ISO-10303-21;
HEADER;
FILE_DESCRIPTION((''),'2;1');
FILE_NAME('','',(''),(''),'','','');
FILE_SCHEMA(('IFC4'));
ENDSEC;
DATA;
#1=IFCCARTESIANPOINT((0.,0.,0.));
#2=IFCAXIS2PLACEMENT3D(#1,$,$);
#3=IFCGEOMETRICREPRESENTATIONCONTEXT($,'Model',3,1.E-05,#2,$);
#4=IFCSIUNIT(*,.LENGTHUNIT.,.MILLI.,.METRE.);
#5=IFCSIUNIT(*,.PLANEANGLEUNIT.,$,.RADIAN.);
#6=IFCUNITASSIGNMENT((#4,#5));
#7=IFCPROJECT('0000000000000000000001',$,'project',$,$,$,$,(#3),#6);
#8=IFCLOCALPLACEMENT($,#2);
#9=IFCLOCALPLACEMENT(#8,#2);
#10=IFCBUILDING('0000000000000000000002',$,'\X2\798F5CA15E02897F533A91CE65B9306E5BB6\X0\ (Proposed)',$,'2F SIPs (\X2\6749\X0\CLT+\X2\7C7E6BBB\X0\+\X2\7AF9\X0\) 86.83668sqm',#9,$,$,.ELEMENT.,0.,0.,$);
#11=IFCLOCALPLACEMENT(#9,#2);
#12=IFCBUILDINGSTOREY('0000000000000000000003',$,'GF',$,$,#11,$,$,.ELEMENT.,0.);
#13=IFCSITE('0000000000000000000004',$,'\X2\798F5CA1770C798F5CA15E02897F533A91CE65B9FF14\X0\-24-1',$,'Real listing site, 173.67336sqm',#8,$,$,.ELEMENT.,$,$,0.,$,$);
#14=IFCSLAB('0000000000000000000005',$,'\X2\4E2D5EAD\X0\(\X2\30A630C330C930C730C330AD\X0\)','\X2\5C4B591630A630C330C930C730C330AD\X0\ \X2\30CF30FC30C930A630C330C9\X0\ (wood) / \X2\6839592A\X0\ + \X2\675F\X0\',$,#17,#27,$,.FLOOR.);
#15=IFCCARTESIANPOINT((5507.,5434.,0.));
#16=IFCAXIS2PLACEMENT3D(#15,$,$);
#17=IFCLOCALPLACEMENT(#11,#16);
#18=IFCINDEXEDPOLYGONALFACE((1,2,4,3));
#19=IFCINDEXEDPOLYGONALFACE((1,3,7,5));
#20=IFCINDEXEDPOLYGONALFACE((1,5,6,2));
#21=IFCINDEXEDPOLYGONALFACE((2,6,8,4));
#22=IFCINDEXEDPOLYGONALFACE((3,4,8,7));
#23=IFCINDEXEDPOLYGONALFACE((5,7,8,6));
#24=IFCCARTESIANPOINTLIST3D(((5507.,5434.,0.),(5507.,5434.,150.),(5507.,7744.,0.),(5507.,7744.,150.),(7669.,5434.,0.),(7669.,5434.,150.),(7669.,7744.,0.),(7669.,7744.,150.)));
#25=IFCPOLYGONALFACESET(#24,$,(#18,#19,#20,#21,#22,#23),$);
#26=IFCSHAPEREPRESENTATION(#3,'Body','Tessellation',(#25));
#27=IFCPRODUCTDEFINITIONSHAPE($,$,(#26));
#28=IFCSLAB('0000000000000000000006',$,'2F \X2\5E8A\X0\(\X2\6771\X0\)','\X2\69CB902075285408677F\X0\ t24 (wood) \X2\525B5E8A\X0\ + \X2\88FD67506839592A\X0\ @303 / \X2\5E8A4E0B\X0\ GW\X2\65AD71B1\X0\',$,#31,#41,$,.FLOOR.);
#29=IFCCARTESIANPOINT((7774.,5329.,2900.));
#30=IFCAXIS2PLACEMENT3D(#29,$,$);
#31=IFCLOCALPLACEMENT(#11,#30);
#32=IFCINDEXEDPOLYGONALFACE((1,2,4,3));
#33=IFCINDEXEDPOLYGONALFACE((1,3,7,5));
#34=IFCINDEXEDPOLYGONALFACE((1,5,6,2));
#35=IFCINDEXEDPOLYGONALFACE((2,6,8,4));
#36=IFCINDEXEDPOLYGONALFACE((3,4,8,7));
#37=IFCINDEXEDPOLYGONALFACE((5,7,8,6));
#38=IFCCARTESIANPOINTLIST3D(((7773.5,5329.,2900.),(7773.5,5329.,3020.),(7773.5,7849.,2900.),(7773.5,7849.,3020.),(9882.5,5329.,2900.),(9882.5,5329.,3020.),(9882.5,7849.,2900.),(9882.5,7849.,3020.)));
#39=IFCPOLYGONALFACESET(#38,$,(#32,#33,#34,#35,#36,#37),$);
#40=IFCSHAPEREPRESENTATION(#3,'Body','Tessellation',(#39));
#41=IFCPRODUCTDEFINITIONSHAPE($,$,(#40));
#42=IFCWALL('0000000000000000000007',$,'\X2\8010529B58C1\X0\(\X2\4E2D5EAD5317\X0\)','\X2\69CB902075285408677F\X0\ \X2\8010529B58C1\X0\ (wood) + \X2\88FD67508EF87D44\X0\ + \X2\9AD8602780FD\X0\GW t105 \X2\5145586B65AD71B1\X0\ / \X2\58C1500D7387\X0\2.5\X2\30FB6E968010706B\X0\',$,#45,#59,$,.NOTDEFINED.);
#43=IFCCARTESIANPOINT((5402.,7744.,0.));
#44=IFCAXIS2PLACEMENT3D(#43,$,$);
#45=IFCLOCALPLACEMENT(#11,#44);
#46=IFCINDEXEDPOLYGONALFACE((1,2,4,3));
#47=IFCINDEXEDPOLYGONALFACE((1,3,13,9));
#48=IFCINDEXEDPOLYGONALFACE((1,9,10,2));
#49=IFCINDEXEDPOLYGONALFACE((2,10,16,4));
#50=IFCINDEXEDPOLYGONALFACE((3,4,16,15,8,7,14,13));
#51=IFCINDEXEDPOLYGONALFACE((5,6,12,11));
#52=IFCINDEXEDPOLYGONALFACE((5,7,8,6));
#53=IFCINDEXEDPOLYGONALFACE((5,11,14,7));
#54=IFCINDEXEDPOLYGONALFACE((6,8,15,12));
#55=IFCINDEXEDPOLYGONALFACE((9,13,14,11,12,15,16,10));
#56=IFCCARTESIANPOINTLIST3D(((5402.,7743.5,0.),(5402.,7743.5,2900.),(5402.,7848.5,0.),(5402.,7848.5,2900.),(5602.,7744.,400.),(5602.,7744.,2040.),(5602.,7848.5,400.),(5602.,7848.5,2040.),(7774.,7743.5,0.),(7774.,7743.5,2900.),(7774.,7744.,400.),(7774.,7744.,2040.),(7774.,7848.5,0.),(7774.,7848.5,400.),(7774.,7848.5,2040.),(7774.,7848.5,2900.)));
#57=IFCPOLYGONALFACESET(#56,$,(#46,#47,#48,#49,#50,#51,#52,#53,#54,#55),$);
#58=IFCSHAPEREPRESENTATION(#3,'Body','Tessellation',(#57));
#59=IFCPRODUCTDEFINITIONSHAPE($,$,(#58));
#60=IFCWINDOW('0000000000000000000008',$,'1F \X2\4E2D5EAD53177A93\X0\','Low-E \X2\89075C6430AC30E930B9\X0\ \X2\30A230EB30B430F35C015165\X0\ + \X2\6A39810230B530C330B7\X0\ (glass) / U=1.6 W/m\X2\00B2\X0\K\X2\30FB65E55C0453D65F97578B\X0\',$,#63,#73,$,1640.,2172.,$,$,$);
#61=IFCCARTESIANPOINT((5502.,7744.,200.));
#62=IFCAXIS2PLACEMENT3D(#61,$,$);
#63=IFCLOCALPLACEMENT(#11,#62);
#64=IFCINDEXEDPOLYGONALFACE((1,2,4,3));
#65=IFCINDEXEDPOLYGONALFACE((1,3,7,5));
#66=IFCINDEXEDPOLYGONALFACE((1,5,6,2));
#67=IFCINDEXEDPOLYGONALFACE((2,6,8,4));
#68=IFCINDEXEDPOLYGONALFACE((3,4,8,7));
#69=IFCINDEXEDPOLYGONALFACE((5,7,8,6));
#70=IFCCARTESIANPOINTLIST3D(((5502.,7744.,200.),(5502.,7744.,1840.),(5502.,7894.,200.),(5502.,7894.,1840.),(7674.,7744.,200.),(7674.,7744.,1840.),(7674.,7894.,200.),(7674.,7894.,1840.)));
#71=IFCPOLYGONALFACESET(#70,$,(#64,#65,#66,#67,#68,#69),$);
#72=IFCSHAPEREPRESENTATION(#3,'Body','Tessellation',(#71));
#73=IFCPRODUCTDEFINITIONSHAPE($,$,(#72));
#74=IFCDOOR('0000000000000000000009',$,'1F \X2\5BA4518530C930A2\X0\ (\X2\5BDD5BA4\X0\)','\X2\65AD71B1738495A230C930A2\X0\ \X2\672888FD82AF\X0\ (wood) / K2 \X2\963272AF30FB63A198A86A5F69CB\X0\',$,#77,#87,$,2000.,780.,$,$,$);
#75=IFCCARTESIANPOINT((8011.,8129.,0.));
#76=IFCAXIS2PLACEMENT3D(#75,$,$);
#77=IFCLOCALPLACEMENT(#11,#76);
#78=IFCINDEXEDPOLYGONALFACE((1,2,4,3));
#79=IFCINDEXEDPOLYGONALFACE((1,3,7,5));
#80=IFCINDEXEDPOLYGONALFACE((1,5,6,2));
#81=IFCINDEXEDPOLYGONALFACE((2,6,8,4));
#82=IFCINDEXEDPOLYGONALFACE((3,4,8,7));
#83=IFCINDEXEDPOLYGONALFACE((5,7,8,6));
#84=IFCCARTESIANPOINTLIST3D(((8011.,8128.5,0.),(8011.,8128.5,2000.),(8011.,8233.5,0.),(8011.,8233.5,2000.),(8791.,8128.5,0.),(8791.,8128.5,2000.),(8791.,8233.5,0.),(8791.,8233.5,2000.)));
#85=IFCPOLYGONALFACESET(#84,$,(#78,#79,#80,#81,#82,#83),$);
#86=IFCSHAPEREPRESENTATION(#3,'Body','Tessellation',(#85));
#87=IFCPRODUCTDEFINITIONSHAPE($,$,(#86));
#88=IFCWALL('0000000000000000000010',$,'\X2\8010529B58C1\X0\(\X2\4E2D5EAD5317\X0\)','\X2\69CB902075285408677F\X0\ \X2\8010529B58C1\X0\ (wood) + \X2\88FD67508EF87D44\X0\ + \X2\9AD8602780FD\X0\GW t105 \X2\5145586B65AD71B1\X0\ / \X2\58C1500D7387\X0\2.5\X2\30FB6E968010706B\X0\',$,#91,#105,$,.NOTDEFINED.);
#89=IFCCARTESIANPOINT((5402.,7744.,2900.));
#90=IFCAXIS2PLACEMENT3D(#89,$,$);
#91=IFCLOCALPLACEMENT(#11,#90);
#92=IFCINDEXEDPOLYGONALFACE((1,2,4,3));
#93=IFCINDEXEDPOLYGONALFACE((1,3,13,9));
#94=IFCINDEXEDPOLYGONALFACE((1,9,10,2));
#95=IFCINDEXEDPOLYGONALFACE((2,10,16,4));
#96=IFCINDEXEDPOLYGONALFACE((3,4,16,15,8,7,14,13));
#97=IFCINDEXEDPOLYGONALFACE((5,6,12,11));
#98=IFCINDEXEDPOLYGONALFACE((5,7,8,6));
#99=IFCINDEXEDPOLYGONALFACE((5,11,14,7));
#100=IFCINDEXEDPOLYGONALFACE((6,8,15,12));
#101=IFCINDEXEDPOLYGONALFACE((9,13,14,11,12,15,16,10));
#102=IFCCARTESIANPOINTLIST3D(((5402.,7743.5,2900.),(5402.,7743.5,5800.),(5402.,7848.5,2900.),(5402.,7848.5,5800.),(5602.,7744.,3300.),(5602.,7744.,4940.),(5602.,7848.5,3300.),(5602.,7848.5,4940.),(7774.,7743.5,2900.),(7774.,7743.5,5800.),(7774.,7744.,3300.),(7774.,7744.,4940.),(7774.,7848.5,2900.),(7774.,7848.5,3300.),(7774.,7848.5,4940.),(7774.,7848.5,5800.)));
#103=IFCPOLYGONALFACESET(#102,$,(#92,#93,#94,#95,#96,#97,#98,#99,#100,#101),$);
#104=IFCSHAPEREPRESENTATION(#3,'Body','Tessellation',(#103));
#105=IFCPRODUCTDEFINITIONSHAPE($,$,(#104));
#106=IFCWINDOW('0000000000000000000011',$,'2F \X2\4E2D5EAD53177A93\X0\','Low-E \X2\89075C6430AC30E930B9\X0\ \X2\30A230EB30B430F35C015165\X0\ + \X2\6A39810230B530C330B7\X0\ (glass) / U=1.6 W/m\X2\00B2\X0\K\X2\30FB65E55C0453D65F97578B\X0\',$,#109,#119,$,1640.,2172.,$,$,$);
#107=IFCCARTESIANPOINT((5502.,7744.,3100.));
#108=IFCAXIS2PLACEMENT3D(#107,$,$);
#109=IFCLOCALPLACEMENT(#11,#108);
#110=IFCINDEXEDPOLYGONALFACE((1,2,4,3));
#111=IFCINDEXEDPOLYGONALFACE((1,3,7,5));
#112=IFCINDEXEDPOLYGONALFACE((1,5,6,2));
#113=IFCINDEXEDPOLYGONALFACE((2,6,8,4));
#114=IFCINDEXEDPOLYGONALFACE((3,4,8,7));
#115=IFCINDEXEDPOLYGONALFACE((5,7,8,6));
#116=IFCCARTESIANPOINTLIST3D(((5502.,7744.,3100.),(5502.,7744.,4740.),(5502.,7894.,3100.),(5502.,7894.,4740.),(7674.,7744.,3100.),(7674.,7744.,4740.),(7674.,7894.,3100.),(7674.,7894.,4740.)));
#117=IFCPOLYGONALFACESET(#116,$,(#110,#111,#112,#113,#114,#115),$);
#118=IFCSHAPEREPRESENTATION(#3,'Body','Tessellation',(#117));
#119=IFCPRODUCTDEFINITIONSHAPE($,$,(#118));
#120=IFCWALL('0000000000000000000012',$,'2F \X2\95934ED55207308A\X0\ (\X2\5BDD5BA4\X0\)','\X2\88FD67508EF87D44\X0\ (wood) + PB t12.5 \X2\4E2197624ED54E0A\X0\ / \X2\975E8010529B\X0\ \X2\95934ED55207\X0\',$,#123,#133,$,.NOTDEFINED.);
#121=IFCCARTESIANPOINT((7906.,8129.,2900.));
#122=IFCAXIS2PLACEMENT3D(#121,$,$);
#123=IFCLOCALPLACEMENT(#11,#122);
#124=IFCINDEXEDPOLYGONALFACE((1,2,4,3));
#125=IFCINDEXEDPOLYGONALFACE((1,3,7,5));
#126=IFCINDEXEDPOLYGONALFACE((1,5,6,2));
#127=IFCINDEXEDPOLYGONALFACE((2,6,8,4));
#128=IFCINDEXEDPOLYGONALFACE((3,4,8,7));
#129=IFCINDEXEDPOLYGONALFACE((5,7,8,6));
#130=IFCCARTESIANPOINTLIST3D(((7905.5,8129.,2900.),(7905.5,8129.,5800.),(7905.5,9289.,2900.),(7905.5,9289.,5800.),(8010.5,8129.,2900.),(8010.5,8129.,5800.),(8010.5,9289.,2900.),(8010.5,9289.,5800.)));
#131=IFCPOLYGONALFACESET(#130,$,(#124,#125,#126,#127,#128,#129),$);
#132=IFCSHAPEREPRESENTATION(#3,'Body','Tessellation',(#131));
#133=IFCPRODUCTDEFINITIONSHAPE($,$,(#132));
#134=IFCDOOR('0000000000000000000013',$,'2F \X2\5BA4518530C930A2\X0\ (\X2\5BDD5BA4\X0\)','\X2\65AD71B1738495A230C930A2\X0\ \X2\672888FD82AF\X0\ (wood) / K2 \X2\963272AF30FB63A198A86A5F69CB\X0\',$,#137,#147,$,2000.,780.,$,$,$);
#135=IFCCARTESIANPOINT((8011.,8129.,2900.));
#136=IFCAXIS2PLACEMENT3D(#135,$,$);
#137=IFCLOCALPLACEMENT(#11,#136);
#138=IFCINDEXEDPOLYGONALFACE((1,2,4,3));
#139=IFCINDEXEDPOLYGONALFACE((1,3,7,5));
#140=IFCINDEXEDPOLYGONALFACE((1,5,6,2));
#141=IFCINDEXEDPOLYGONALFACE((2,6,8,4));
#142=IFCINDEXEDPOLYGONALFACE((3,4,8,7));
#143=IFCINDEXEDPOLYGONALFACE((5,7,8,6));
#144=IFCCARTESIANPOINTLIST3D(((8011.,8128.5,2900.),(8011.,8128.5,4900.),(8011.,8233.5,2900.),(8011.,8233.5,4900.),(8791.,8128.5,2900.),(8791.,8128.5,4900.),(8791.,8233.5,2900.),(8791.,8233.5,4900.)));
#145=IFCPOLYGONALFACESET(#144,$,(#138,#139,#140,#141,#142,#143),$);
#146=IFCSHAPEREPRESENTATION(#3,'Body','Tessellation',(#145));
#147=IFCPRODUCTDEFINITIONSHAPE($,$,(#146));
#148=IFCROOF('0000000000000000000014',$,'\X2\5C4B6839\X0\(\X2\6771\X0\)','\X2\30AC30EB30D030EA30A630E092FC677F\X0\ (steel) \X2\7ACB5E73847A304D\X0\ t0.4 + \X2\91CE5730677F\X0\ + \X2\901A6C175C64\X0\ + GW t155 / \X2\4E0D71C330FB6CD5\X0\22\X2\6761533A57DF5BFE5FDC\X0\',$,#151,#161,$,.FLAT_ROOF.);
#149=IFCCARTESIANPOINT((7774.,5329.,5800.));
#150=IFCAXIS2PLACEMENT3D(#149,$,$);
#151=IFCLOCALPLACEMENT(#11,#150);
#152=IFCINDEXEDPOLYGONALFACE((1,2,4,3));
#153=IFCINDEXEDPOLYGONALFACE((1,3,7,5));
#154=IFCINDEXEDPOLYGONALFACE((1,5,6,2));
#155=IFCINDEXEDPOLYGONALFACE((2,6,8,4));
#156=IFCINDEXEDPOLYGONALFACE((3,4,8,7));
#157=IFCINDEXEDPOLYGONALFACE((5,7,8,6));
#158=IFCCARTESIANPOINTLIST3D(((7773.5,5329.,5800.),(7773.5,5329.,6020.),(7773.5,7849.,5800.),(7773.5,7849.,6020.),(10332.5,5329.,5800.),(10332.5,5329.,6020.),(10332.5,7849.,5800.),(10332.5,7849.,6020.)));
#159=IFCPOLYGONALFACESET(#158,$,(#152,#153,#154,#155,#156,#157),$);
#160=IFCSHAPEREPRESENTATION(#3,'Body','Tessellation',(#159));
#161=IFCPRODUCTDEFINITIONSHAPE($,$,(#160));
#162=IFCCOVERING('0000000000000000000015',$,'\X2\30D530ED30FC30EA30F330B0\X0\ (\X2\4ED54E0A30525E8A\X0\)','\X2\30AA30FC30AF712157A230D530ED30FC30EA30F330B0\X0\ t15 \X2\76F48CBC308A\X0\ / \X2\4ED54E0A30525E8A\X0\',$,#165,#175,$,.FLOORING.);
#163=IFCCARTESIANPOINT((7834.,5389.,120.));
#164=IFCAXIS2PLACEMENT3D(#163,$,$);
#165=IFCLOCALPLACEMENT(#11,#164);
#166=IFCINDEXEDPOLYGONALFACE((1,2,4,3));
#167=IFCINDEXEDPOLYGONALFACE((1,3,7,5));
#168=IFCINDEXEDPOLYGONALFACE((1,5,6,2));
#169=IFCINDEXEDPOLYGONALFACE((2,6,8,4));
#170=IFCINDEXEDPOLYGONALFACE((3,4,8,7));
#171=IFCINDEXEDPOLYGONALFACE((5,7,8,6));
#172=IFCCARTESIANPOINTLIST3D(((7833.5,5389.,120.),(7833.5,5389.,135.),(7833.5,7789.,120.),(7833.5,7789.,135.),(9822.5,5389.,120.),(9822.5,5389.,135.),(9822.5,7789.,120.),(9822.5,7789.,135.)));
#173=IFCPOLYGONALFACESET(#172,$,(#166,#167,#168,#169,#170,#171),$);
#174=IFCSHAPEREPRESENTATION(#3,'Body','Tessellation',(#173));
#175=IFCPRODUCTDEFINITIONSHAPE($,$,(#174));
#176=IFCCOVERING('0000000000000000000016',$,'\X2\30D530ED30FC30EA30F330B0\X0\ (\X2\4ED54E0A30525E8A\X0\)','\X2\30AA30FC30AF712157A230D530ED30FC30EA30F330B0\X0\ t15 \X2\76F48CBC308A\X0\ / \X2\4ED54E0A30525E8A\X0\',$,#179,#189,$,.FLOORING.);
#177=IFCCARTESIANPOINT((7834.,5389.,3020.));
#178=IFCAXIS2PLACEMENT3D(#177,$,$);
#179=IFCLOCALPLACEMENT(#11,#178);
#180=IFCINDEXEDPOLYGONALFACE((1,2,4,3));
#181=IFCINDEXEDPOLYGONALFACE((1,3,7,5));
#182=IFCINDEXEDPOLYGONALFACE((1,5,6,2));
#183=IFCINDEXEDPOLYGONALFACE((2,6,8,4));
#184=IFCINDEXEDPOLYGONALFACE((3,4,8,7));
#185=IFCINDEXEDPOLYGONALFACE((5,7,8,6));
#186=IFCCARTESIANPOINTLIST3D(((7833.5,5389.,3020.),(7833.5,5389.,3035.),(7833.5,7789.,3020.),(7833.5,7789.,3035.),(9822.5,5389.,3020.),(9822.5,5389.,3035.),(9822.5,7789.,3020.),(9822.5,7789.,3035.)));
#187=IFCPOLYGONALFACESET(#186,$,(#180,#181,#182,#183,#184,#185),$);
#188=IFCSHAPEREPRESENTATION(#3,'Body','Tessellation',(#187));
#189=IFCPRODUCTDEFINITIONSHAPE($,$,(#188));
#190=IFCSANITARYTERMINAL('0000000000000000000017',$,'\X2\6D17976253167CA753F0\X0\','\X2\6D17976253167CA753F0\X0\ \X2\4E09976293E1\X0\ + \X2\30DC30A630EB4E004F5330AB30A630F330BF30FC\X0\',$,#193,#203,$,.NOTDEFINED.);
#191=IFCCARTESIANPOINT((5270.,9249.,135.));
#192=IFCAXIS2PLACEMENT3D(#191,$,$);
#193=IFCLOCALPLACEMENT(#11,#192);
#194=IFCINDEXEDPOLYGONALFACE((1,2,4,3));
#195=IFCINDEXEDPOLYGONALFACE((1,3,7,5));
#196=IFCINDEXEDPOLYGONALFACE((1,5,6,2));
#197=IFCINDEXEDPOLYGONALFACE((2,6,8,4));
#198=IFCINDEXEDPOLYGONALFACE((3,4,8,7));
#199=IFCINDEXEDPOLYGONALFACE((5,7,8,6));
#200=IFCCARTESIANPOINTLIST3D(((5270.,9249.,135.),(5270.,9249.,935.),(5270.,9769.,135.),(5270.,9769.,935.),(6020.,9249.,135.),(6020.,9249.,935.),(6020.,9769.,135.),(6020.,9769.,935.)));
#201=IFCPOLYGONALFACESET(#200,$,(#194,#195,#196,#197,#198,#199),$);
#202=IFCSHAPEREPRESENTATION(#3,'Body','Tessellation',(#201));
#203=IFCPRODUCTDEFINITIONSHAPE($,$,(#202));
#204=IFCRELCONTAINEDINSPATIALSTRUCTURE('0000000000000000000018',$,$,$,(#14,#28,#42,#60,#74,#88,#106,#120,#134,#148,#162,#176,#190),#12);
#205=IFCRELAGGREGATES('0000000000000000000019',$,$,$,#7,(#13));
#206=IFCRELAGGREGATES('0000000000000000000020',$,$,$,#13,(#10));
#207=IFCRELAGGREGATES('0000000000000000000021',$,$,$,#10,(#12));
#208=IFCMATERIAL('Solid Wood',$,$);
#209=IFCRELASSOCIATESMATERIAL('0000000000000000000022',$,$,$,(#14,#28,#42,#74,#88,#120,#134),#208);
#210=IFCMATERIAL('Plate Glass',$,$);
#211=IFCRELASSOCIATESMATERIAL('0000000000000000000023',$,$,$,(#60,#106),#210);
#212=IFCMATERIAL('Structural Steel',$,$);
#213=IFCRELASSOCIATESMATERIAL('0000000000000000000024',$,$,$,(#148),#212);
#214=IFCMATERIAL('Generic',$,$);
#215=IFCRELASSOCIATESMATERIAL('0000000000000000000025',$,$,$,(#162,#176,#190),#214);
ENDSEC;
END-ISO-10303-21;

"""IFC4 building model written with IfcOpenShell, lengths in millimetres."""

from ifc_helpers import new_model, si_unit, frame, frame_2d, origin, place, context, project, spatial, rectangle, extrude, material, element, fill, save


model = new_model("IFC4")

# Units and contexts
model_context = context("Model", 3, precision=1e-05, world=origin())
ifc_project = project(units=[si_unit("LENGTHUNIT", "METRE", prefix="MILLI"), si_unit("PLANEANGLEUNIT", "RADIAN")], contexts=[model_context])

# Site, building, storey
site_placement = place(None, origin())
site = spatial("IfcSite", under=ifc_project, at=site_placement, Name="福岡県福岡市西区野方４-24-1", ObjectType="Real listing site, 173.67336sqm", CompositionType="ELEMENT", RefElevation=0.0)
building_placement = place(site_placement, origin())
building = spatial("IfcBuilding", under=site, at=building_placement, Name="福岡市西区野方の家 (Proposed)", ObjectType="2F SIPs (杉CLT+籾殻+竹) 86.83668sqm", CompositionType="ELEMENT", ElevationOfRefHeight=0.0, ElevationOfTerrain=0.0)
storey_placement = place(building_placement, origin())
storey = spatial("IfcBuildingStorey", under=building, at=storey_placement, Name="GF", CompositionType="ELEMENT", Elevation=0.0)

# Slabs
ifc_material_1 = material(Name="Solid Wood")
slab_1_placement = place(storey_placement, frame((5507.0, 5434.0, 0.0)))
element("IfcSlab", 1, at=slab_1_placement, inside=storey, material=ifc_material_1, Name="中庭(ウッドデッキ)", Description="屋外ウッドデッキ ハードウッド (wood) / 根太 + 束", PredefinedType="FLOOR", context=model_context, shape_type="SweptSolid", body=[
    extrude(rectangle(XDim=2162.0, YDim=2310.0, at=frame_2d((1081.0, 1155.0))), frame((5507.0, 5434.0, 0.0)), (0.0, 0.0, 1.0), 150.0),
])
slab_2_placement = place(storey_placement, frame((7774.0, 5329.0, 2900.0)))
element("IfcSlab", 2, at=slab_2_placement, inside=storey, material=ifc_material_1, Name="2F 床(東)", Description="構造用合板 t24 (wood) 剛床 + 製材根太 @303 / 床下 GW断熱", PredefinedType="FLOOR", context=model_context, shape_type="SweptSolid", body=[
    extrude(rectangle(XDim=2109.0, YDim=2520.0, at=frame_2d((1054.0, 1260.0))), frame((7774.0, 5329.0, 2900.0)), (0.0, 0.0, 1.0), 120.0),
])

# Wall, opening, window
wall_1_placement = place(storey_placement, frame((5402.0, 7744.0, 0.0)))
wall_1 = element("IfcWall", 3, at=wall_1_placement, inside=storey, material=ifc_material_1, Name="耐力壁(中庭北)", Description="構造用合板 耐力壁 (wood) + 製材軸組 + 高性能GW t105 充填断熱 / 壁倍率2.5・準耐火", PredefinedType="NOTDEFINED", context=model_context, shape_type="SweptSolid", body=[
    extrude(rectangle(XDim=2372.0, YDim=105.0, at=frame_2d((1186.0, 52.0))), frame((5402.0, 7744.0, 0.0)), (0.0, 0.0, 1.0), 2900.0),
])
opening_1_placement = place(storey_placement, frame((5502.0, 7744.0, 200.0)))
opening_1 = element("IfcOpeningElement", 4, at=opening_1_placement, cuts=wall_1, PredefinedType="NOTDEFINED", context=model_context, shape_type="SweptSolid", body=[
    extrude(rectangle(XDim=2172.0, YDim=150.0, at=frame_2d((1086.0, 75.0))), frame((5502.0, 7744.0, 200.0)), (0.0, 0.0, 1.0), 1640.0),
])
ifc_material_2 = material(Name="Plate Glass")
window_1_placement = place(storey_placement, frame((5502.0, 7744.0, 200.0)))
window_1 = element("IfcWindow", 5, at=window_1_placement, inside=storey, material=ifc_material_2, Name="1F 中庭北窓", Description="Low-E 複層ガラス アルゴン封入 + 樹脂サッシ (glass) / U=1.6 W/m²K・日射取得型", OverallHeight=1640.0, OverallWidth=2172.0, context=model_context, shape_type="SweptSolid", body=[
    extrude(rectangle(XDim=2172.0, YDim=150.0, at=frame_2d((1086.0, 75.0))), frame((5502.0, 7744.0, 200.0)), (0.0, 0.0, 1.0), 1640.0),
])
fill(opening_1, window_1)

# Door
door_1_placement = place(storey_placement, frame((8011.0, 8129.0, 0.0)))
element("IfcDoor", 6, at=door_1_placement, inside=storey, material=ifc_material_1, Name="1F 室内ドア (寝室)", Description="断熱玄関ドア 木製芯 (wood) / K2 防犯・採風機構", OverallHeight=2000.0, OverallWidth=780.0, context=model_context, shape_type="SweptSolid", body=[
    extrude(rectangle(XDim=780.0, YDim=105.0, at=frame_2d((390.0, 52.0))), frame((8011.0, 8129.0, 0.0)), (0.0, 0.0, 1.0), 2000.0),
])

# Wall, opening, window
wall_2_placement = place(storey_placement, frame((5402.0, 7744.0, 2900.0)))
wall_2 = element("IfcWall", 7, at=wall_2_placement, inside=storey, material=ifc_material_1, Name="耐力壁(中庭北)", Description="構造用合板 耐力壁 (wood) + 製材軸組 + 高性能GW t105 充填断熱 / 壁倍率2.5・準耐火", PredefinedType="NOTDEFINED", context=model_context, shape_type="SweptSolid", body=[
    extrude(rectangle(XDim=2372.0, YDim=105.0, at=frame_2d((1186.0, 52.0))), frame((5402.0, 7744.0, 2900.0)), (0.0, 0.0, 1.0), 2900.0),
])
opening_2_placement = place(storey_placement, frame((5502.0, 7744.0, 3100.0)))
opening_2 = element("IfcOpeningElement", 8, at=opening_2_placement, cuts=wall_2, PredefinedType="NOTDEFINED", context=model_context, shape_type="SweptSolid", body=[
    extrude(rectangle(XDim=2172.0, YDim=150.0, at=frame_2d((1086.0, 75.0))), frame((5502.0, 7744.0, 3100.0)), (0.0, 0.0, 1.0), 1640.0),
])
window_2_placement = place(storey_placement, frame((5502.0, 7744.0, 3100.0)))
window_2 = element("IfcWindow", 9, at=window_2_placement, inside=storey, material=ifc_material_2, Name="2F 中庭北窓", Description="Low-E 複層ガラス アルゴン封入 + 樹脂サッシ (glass) / U=1.6 W/m²K・日射取得型", OverallHeight=1640.0, OverallWidth=2172.0, context=model_context, shape_type="SweptSolid", body=[
    extrude(rectangle(XDim=2172.0, YDim=150.0, at=frame_2d((1086.0, 75.0))), frame((5502.0, 7744.0, 3100.0)), (0.0, 0.0, 1.0), 1640.0),
])
fill(opening_2, window_2)

# Wall
wall_3_placement = place(storey_placement, frame((7906.0, 8129.0, 2900.0)))
element("IfcWall", 10, at=wall_3_placement, inside=storey, material=ifc_material_1, Name="2F 間仕切り (寝室)", Description="製材軸組 (wood) + PB t12.5 両面仕上 / 非耐力 間仕切", PredefinedType="NOTDEFINED", context=model_context, shape_type="SweptSolid", body=[
    extrude(rectangle(XDim=105.0, YDim=1160.0, at=frame_2d((52.0, 580.0))), frame((7906.0, 8129.0, 2900.0)), (0.0, 0.0, 1.0), 2900.0),
])

# Door
door_2_placement = place(storey_placement, frame((8011.0, 8129.0, 2900.0)))
element("IfcDoor", 11, at=door_2_placement, inside=storey, material=ifc_material_1, Name="2F 室内ドア (寝室)", Description="断熱玄関ドア 木製芯 (wood) / K2 防犯・採風機構", OverallHeight=2000.0, OverallWidth=780.0, context=model_context, shape_type="SweptSolid", body=[
    extrude(rectangle(XDim=780.0, YDim=105.0, at=frame_2d((390.0, 52.0))), frame((8011.0, 8129.0, 2900.0)), (0.0, 0.0, 1.0), 2000.0),
])

# Roof
ifc_material_3 = material(Name="Structural Steel")
for number, where, name in (
    (12, (7774.0, 5329.0, 5800.0), "屋根(東)"),
):
    element("IfcRoof", number, at=place(storey_placement, frame(where)), inside=storey, material=ifc_material_3, Name=name, Description="ガルバリウム鋼板 (steel) 立平葺き t0.4 + 野地板 + 通気層 + GW t155 / 不燃・法22条区域対応", PredefinedType="FLAT_ROOF", context=model_context, shape_type="SweptSolid", body=[
        extrude(rectangle(XDim=2559.0, YDim=2520.0, at=frame_2d((1279.0, 1260.0))), frame((7774.0, 5329.0, 5800.0)), (0.0, 0.0, 1.0), 220.0),
    ])

# Coverings
ifc_material_4 = material(Name="Generic")
covering_1_placement = place(storey_placement, frame((7834.0, 5389.0, 120.0)))
element("IfcCovering", 13, at=covering_1_placement, inside=storey, material=ifc_material_4, Name="フローリング (仕上げ床)", Description="オーク無垢フローリング t15 直貼り / 仕上げ床", PredefinedType="FLOORING", context=model_context, shape_type="SweptSolid", body=[
    extrude(rectangle(XDim=1989.0, YDim=2400.0, at=frame_2d((994.0, 1200.0))), frame((7834.0, 5389.0, 120.0)), (0.0, 0.0, 1.0), 15.0),
])
covering_2_placement = place(storey_placement, frame((7834.0, 5389.0, 3020.0)))
element("IfcCovering", 14, at=covering_2_placement, inside=storey, material=ifc_material_4, Name="フローリング (仕上げ床)", Description="オーク無垢フローリング t15 直貼り / 仕上げ床", PredefinedType="FLOORING", context=model_context, shape_type="SweptSolid", body=[
    extrude(rectangle(XDim=1989.0, YDim=2400.0, at=frame_2d((994.0, 1200.0))), frame((7834.0, 5389.0, 3020.0)), (0.0, 0.0, 1.0), 15.0),
])

# Sanitary terminal
sanitary_terminal_1_placement = place(storey_placement, frame((5270.0, 9249.0, 135.0)))
element("IfcSanitaryTerminal", 15, at=sanitary_terminal_1_placement, inside=storey, material=ifc_material_4, Name="洗面化粧台", Description="洗面化粧台 三面鏡 + ボウル一体カウンター", PredefinedType="NOTDEFINED", context=model_context, shape_type="SweptSolid", body=[
    extrude(rectangle(XDim=750.0, YDim=520.0, at=frame_2d((375.0, 260.0))), frame((5270.0, 9249.0, 135.0)), (0.0, 0.0, 1.0), 800.0),
])

save(model, "model.ifc")
